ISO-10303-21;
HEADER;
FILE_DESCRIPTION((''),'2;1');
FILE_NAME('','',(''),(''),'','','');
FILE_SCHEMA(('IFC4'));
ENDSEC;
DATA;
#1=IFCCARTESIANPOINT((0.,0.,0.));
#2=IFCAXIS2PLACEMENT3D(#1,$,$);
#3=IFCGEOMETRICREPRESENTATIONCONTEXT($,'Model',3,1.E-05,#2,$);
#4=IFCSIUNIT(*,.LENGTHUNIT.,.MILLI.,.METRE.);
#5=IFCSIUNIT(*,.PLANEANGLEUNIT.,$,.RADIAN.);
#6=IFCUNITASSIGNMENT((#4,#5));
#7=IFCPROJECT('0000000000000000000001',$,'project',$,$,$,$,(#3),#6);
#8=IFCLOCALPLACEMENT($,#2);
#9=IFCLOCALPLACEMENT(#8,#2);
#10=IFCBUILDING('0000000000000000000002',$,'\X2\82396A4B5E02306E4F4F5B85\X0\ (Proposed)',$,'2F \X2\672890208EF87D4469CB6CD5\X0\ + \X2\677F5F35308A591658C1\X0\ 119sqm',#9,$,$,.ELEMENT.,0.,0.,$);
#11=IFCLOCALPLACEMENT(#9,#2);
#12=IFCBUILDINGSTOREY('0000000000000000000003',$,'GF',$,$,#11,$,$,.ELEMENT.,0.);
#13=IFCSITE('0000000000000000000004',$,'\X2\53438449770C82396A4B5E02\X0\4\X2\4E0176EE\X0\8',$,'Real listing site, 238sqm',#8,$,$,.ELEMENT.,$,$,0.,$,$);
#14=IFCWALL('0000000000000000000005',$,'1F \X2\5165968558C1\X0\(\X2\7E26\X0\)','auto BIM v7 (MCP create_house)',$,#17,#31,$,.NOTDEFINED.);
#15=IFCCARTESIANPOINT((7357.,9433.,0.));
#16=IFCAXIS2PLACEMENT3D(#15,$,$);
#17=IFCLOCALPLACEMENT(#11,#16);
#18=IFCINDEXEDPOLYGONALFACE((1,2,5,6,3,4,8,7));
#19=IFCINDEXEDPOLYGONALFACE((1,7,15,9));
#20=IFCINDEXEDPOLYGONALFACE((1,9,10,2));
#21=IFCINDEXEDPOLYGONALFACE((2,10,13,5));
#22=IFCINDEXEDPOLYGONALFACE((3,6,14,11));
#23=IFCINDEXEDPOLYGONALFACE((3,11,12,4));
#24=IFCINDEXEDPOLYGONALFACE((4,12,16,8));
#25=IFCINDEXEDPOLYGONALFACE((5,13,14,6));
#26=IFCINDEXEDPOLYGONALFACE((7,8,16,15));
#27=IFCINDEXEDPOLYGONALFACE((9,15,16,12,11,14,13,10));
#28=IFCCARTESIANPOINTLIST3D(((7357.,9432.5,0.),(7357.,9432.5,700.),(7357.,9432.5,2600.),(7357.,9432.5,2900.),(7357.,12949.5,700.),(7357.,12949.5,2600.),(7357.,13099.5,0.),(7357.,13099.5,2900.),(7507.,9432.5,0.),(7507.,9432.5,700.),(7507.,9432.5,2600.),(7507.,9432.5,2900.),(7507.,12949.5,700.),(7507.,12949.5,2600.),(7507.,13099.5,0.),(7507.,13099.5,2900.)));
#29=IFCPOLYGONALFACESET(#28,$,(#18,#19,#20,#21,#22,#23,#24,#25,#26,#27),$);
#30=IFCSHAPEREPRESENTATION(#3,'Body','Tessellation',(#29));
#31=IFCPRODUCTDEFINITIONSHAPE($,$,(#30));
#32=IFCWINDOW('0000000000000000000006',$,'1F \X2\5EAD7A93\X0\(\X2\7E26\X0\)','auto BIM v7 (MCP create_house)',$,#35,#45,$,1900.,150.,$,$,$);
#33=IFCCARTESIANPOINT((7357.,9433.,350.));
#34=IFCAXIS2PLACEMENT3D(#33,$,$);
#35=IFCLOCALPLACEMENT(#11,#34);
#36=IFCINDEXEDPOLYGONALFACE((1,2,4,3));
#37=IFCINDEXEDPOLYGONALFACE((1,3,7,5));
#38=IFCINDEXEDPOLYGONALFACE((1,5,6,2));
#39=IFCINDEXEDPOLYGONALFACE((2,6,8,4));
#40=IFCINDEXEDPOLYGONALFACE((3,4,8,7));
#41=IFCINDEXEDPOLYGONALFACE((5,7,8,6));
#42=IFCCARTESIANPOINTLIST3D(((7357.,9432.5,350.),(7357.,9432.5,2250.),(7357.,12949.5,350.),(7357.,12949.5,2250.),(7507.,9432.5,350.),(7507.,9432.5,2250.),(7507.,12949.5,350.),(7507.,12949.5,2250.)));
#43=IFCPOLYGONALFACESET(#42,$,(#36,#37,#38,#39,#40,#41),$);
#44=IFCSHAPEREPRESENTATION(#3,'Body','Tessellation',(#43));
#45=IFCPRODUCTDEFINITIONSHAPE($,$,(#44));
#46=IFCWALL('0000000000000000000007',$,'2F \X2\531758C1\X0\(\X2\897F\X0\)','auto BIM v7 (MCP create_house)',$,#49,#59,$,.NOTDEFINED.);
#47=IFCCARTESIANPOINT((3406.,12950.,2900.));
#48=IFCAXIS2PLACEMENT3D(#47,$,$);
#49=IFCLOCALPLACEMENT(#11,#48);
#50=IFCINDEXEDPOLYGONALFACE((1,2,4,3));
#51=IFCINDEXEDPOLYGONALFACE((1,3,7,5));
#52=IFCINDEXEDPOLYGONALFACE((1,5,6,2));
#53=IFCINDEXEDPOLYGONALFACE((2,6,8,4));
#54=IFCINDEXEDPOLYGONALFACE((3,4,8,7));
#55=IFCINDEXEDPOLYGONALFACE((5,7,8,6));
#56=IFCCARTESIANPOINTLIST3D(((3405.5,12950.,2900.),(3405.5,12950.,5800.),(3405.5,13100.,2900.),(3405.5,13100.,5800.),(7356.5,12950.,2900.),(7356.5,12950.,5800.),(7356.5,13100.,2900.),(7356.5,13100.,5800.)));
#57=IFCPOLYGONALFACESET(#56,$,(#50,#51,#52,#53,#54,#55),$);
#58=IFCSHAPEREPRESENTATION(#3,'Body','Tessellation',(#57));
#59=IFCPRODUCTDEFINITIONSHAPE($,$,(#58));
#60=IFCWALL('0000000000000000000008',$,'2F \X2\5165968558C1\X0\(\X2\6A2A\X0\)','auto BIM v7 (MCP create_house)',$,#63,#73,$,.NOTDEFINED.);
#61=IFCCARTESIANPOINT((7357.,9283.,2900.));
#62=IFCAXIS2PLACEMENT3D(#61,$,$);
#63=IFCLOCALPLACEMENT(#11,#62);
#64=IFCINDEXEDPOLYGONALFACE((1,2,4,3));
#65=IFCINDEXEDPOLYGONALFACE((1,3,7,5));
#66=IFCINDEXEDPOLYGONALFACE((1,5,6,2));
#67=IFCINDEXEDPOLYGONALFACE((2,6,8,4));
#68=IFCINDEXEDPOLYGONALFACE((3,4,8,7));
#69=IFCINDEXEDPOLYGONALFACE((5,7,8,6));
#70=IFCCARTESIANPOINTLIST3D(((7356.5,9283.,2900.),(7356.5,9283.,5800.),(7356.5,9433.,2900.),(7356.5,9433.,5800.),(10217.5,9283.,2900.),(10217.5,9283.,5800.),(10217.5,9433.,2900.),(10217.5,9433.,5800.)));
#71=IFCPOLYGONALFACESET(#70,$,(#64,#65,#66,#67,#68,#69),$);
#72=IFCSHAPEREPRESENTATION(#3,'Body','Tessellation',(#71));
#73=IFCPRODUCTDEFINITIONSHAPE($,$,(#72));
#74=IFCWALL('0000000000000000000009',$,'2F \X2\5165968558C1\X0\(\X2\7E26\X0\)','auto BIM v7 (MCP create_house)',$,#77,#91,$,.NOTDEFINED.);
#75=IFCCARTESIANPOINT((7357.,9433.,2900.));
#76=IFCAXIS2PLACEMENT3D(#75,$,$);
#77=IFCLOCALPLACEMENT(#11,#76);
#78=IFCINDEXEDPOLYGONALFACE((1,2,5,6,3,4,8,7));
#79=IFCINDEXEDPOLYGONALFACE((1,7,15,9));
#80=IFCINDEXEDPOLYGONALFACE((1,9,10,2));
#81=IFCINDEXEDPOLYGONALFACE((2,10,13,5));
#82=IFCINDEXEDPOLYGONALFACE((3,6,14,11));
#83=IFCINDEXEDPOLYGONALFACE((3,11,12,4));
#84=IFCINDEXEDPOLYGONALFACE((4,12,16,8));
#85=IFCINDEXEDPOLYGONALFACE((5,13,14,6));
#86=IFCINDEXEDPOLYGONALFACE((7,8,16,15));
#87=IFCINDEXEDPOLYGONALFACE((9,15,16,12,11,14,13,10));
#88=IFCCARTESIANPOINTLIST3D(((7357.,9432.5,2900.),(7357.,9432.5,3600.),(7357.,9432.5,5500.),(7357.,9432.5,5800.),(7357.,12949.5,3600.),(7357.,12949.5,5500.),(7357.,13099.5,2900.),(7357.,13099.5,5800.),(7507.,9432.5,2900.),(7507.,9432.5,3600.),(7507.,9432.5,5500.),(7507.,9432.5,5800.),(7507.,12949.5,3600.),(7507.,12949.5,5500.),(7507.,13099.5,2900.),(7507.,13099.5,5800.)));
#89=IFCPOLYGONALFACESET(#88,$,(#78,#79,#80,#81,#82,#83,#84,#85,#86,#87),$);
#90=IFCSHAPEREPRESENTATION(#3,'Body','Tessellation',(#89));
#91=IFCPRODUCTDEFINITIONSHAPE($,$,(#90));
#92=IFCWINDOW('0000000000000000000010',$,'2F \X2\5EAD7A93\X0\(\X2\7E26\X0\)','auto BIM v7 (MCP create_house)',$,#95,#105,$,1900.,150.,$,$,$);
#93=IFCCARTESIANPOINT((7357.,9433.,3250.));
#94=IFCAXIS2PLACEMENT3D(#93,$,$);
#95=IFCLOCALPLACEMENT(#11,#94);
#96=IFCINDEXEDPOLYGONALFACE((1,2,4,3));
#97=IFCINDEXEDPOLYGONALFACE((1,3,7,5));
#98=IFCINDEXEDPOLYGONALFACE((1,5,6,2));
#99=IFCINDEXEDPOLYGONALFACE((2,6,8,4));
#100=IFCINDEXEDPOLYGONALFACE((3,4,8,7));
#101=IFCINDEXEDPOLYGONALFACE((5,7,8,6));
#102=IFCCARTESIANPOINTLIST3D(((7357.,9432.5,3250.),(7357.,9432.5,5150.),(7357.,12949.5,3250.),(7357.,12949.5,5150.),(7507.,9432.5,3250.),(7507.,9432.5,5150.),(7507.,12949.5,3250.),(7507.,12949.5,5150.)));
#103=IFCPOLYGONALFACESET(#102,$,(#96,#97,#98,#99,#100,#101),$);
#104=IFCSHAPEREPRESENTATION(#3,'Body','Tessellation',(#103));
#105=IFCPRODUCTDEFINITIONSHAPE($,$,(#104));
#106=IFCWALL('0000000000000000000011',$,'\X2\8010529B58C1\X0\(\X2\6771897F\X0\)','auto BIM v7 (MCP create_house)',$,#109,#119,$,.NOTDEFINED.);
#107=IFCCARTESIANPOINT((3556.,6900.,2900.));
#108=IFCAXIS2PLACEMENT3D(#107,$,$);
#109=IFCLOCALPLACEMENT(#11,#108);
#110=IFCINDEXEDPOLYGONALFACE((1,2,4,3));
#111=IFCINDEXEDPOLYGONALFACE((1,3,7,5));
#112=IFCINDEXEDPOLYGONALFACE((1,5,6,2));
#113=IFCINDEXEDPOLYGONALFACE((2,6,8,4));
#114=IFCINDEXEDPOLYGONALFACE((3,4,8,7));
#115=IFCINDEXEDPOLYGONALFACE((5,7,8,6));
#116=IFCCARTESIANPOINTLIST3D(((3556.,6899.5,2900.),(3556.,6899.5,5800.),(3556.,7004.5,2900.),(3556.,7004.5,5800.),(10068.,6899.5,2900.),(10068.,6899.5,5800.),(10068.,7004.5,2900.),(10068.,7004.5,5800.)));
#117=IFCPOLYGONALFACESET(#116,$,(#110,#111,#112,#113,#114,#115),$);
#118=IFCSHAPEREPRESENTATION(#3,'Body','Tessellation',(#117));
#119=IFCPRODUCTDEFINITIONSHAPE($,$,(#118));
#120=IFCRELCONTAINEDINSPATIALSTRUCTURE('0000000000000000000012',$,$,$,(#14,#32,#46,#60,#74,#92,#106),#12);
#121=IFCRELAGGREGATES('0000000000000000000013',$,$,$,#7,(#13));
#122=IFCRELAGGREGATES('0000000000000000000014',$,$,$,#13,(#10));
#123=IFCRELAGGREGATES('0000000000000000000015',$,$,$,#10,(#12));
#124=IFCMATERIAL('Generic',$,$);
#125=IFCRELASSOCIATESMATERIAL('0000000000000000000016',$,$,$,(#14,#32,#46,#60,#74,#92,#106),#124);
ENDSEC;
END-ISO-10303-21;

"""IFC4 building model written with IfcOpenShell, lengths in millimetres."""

from ifc_helpers import new_model, si_unit, frame, frame_2d, origin, place, context, project, spatial, rectangle, extrude, material, element, fill, save


model = new_model("IFC4")

# Units and contexts
model_context = context("Model", 3, precision=1e-05, world=origin())
ifc_project = project(units=[si_unit("LENGTHUNIT", "METRE", prefix="MILLI"), si_unit("PLANEANGLEUNIT", "RADIAN")], contexts=[model_context])

# Site, building, storey
site_placement = place(None, origin())
site = spatial("IfcSite", under=ifc_project, at=site_placement, Name="千葉県船橋市4丁目8", ObjectType="Real listing site, 238sqm", CompositionType="ELEMENT", RefElevation=0.0)
building_placement = place(site_placement, origin())
building = spatial("IfcBuilding", under=site, at=building_placement, Name="船橋市の住宅 (Proposed)", ObjectType="2F 木造軸組構法 + 板張り外壁 119sqm", CompositionType="ELEMENT", ElevationOfRefHeight=0.0, ElevationOfTerrain=0.0)
storey_placement = place(building_placement, origin())
storey = spatial("IfcBuildingStorey", under=building, at=storey_placement, Name="GF", CompositionType="ELEMENT", Elevation=0.0)

# Shared definitions
ifc_material = material(Name="Generic")

# Wall, opening, window
wall_1_placement = place(storey_placement, frame((7357.0, 9433.0, 0.0)))
wall_1 = element("IfcWall", 1, at=wall_1_placement, inside=storey, material=ifc_material, Name="1F 入隅壁(縦)", Description="auto BIM v7 (MCP create_house)", PredefinedType="NOTDEFINED", context=model_context, shape_type="SweptSolid", body=[
    extrude(rectangle(XDim=150.0, YDim=3667.0, at=frame_2d((75.0, 1833.0))), frame((7357.0, 9433.0, 0.0)), (0.0, 0.0, 1.0), 2900.0),
])
opening_1_placement = place(storey_placement, frame((7357.0, 9433.0, 350.0)))
opening_1 = element("IfcOpeningElement", 2, at=opening_1_placement, cuts=wall_1, PredefinedType="NOTDEFINED", context=model_context, shape_type="SweptSolid", body=[
    extrude(rectangle(XDim=150.0, YDim=3517.0, at=frame_2d((75.0, 1758.0))), frame((7357.0, 9433.0, 350.0)), (0.0, 0.0, 1.0), 1900.0),
])
window_1_placement = place(storey_placement, frame((7357.0, 9433.0, 350.0)))
window_1 = element("IfcWindow", 3, at=window_1_placement, inside=storey, material=ifc_material, Name="1F 庭窓(縦)", Description="auto BIM v7 (MCP create_house)", OverallHeight=1900.0, OverallWidth=150.0, context=model_context, shape_type="SweptSolid", body=[
    extrude(rectangle(XDim=150.0, YDim=3517.0, at=frame_2d((75.0, 1758.0))), frame((7357.0, 9433.0, 350.0)), (0.0, 0.0, 1.0), 1900.0),
])
fill(opening_1, window_1)

# Walls
wall_2_placement = place(storey_placement, frame((3406.0, 12950.0, 2900.0)))
element("IfcWall", 4, at=wall_2_placement, inside=storey, material=ifc_material, Name="2F 北壁(西)", Description="auto BIM v7 (MCP create_house)", PredefinedType="NOTDEFINED", context=model_context, shape_type="SweptSolid", body=[
    extrude(rectangle(XDim=3951.0, YDim=150.0, at=frame_2d((1975.0, 75.0))), frame((3406.0, 12950.0, 2900.0)), (0.0, 0.0, 1.0), 2900.0),
])
wall_3_placement = place(storey_placement, frame((7357.0, 9283.0, 2900.0)))
element("IfcWall", 5, at=wall_3_placement, inside=storey, material=ifc_material, Name="2F 入隅壁(横)", Description="auto BIM v7 (MCP create_house)", PredefinedType="NOTDEFINED", context=model_context, shape_type="SweptSolid", body=[
    extrude(rectangle(XDim=2861.0, YDim=150.0, at=frame_2d((1430.0, 75.0))), frame((7357.0, 9283.0, 2900.0)), (0.0, 0.0, 1.0), 2900.0),
])

# Wall, opening, window
wall_4_placement = place(storey_placement, frame((7357.0, 9433.0, 2900.0)))
wall_4 = element("IfcWall", 6, at=wall_4_placement, inside=storey, material=ifc_material, Name="2F 入隅壁(縦)", Description="auto BIM v7 (MCP create_house)", PredefinedType="NOTDEFINED", context=model_context, shape_type="SweptSolid", body=[
    extrude(rectangle(XDim=150.0, YDim=3667.0, at=frame_2d((75.0, 1833.0))), frame((7357.0, 9433.0, 2900.0)), (0.0, 0.0, 1.0), 2900.0),
])
opening_2_placement = place(storey_placement, frame((7357.0, 9433.0, 3250.0)))
opening_2 = element("IfcOpeningElement", 7, at=opening_2_placement, cuts=wall_4, PredefinedType="NOTDEFINED", context=model_context, shape_type="SweptSolid", body=[
    extrude(rectangle(XDim=150.0, YDim=3517.0, at=frame_2d((75.0, 1758.0))), frame((7357.0, 9433.0, 3250.0)), (0.0, 0.0, 1.0), 1900.0),
])
window_2_placement = place(storey_placement, frame((7357.0, 9433.0, 3250.0)))
window_2 = element("IfcWindow", 8, at=window_2_placement, inside=storey, material=ifc_material, Name="2F 庭窓(縦)", Description="auto BIM v7 (MCP create_house)", OverallHeight=1900.0, OverallWidth=150.0, context=model_context, shape_type="SweptSolid", body=[
    extrude(rectangle(XDim=150.0, YDim=3517.0, at=frame_2d((75.0, 1758.0))), frame((7357.0, 9433.0, 3250.0)), (0.0, 0.0, 1.0), 1900.0),
])
fill(opening_2, window_2)

# Wall
wall_5_placement = place(storey_placement, frame((3556.0, 6900.0, 2900.0)))
element("IfcWall", 9, at=wall_5_placement, inside=storey, material=ifc_material, Name="耐力壁(東西)", Description="auto BIM v7 (MCP create_house)", PredefinedType="NOTDEFINED", context=model_context, shape_type="SweptSolid", body=[
    extrude(rectangle(XDim=6512.0, YDim=105.0, at=frame_2d((3256.0, 52.0))), frame((3556.0, 6900.0, 2900.0)), (0.0, 0.0, 1.0), 2900.0),
])

save(model, "model.ifc")
